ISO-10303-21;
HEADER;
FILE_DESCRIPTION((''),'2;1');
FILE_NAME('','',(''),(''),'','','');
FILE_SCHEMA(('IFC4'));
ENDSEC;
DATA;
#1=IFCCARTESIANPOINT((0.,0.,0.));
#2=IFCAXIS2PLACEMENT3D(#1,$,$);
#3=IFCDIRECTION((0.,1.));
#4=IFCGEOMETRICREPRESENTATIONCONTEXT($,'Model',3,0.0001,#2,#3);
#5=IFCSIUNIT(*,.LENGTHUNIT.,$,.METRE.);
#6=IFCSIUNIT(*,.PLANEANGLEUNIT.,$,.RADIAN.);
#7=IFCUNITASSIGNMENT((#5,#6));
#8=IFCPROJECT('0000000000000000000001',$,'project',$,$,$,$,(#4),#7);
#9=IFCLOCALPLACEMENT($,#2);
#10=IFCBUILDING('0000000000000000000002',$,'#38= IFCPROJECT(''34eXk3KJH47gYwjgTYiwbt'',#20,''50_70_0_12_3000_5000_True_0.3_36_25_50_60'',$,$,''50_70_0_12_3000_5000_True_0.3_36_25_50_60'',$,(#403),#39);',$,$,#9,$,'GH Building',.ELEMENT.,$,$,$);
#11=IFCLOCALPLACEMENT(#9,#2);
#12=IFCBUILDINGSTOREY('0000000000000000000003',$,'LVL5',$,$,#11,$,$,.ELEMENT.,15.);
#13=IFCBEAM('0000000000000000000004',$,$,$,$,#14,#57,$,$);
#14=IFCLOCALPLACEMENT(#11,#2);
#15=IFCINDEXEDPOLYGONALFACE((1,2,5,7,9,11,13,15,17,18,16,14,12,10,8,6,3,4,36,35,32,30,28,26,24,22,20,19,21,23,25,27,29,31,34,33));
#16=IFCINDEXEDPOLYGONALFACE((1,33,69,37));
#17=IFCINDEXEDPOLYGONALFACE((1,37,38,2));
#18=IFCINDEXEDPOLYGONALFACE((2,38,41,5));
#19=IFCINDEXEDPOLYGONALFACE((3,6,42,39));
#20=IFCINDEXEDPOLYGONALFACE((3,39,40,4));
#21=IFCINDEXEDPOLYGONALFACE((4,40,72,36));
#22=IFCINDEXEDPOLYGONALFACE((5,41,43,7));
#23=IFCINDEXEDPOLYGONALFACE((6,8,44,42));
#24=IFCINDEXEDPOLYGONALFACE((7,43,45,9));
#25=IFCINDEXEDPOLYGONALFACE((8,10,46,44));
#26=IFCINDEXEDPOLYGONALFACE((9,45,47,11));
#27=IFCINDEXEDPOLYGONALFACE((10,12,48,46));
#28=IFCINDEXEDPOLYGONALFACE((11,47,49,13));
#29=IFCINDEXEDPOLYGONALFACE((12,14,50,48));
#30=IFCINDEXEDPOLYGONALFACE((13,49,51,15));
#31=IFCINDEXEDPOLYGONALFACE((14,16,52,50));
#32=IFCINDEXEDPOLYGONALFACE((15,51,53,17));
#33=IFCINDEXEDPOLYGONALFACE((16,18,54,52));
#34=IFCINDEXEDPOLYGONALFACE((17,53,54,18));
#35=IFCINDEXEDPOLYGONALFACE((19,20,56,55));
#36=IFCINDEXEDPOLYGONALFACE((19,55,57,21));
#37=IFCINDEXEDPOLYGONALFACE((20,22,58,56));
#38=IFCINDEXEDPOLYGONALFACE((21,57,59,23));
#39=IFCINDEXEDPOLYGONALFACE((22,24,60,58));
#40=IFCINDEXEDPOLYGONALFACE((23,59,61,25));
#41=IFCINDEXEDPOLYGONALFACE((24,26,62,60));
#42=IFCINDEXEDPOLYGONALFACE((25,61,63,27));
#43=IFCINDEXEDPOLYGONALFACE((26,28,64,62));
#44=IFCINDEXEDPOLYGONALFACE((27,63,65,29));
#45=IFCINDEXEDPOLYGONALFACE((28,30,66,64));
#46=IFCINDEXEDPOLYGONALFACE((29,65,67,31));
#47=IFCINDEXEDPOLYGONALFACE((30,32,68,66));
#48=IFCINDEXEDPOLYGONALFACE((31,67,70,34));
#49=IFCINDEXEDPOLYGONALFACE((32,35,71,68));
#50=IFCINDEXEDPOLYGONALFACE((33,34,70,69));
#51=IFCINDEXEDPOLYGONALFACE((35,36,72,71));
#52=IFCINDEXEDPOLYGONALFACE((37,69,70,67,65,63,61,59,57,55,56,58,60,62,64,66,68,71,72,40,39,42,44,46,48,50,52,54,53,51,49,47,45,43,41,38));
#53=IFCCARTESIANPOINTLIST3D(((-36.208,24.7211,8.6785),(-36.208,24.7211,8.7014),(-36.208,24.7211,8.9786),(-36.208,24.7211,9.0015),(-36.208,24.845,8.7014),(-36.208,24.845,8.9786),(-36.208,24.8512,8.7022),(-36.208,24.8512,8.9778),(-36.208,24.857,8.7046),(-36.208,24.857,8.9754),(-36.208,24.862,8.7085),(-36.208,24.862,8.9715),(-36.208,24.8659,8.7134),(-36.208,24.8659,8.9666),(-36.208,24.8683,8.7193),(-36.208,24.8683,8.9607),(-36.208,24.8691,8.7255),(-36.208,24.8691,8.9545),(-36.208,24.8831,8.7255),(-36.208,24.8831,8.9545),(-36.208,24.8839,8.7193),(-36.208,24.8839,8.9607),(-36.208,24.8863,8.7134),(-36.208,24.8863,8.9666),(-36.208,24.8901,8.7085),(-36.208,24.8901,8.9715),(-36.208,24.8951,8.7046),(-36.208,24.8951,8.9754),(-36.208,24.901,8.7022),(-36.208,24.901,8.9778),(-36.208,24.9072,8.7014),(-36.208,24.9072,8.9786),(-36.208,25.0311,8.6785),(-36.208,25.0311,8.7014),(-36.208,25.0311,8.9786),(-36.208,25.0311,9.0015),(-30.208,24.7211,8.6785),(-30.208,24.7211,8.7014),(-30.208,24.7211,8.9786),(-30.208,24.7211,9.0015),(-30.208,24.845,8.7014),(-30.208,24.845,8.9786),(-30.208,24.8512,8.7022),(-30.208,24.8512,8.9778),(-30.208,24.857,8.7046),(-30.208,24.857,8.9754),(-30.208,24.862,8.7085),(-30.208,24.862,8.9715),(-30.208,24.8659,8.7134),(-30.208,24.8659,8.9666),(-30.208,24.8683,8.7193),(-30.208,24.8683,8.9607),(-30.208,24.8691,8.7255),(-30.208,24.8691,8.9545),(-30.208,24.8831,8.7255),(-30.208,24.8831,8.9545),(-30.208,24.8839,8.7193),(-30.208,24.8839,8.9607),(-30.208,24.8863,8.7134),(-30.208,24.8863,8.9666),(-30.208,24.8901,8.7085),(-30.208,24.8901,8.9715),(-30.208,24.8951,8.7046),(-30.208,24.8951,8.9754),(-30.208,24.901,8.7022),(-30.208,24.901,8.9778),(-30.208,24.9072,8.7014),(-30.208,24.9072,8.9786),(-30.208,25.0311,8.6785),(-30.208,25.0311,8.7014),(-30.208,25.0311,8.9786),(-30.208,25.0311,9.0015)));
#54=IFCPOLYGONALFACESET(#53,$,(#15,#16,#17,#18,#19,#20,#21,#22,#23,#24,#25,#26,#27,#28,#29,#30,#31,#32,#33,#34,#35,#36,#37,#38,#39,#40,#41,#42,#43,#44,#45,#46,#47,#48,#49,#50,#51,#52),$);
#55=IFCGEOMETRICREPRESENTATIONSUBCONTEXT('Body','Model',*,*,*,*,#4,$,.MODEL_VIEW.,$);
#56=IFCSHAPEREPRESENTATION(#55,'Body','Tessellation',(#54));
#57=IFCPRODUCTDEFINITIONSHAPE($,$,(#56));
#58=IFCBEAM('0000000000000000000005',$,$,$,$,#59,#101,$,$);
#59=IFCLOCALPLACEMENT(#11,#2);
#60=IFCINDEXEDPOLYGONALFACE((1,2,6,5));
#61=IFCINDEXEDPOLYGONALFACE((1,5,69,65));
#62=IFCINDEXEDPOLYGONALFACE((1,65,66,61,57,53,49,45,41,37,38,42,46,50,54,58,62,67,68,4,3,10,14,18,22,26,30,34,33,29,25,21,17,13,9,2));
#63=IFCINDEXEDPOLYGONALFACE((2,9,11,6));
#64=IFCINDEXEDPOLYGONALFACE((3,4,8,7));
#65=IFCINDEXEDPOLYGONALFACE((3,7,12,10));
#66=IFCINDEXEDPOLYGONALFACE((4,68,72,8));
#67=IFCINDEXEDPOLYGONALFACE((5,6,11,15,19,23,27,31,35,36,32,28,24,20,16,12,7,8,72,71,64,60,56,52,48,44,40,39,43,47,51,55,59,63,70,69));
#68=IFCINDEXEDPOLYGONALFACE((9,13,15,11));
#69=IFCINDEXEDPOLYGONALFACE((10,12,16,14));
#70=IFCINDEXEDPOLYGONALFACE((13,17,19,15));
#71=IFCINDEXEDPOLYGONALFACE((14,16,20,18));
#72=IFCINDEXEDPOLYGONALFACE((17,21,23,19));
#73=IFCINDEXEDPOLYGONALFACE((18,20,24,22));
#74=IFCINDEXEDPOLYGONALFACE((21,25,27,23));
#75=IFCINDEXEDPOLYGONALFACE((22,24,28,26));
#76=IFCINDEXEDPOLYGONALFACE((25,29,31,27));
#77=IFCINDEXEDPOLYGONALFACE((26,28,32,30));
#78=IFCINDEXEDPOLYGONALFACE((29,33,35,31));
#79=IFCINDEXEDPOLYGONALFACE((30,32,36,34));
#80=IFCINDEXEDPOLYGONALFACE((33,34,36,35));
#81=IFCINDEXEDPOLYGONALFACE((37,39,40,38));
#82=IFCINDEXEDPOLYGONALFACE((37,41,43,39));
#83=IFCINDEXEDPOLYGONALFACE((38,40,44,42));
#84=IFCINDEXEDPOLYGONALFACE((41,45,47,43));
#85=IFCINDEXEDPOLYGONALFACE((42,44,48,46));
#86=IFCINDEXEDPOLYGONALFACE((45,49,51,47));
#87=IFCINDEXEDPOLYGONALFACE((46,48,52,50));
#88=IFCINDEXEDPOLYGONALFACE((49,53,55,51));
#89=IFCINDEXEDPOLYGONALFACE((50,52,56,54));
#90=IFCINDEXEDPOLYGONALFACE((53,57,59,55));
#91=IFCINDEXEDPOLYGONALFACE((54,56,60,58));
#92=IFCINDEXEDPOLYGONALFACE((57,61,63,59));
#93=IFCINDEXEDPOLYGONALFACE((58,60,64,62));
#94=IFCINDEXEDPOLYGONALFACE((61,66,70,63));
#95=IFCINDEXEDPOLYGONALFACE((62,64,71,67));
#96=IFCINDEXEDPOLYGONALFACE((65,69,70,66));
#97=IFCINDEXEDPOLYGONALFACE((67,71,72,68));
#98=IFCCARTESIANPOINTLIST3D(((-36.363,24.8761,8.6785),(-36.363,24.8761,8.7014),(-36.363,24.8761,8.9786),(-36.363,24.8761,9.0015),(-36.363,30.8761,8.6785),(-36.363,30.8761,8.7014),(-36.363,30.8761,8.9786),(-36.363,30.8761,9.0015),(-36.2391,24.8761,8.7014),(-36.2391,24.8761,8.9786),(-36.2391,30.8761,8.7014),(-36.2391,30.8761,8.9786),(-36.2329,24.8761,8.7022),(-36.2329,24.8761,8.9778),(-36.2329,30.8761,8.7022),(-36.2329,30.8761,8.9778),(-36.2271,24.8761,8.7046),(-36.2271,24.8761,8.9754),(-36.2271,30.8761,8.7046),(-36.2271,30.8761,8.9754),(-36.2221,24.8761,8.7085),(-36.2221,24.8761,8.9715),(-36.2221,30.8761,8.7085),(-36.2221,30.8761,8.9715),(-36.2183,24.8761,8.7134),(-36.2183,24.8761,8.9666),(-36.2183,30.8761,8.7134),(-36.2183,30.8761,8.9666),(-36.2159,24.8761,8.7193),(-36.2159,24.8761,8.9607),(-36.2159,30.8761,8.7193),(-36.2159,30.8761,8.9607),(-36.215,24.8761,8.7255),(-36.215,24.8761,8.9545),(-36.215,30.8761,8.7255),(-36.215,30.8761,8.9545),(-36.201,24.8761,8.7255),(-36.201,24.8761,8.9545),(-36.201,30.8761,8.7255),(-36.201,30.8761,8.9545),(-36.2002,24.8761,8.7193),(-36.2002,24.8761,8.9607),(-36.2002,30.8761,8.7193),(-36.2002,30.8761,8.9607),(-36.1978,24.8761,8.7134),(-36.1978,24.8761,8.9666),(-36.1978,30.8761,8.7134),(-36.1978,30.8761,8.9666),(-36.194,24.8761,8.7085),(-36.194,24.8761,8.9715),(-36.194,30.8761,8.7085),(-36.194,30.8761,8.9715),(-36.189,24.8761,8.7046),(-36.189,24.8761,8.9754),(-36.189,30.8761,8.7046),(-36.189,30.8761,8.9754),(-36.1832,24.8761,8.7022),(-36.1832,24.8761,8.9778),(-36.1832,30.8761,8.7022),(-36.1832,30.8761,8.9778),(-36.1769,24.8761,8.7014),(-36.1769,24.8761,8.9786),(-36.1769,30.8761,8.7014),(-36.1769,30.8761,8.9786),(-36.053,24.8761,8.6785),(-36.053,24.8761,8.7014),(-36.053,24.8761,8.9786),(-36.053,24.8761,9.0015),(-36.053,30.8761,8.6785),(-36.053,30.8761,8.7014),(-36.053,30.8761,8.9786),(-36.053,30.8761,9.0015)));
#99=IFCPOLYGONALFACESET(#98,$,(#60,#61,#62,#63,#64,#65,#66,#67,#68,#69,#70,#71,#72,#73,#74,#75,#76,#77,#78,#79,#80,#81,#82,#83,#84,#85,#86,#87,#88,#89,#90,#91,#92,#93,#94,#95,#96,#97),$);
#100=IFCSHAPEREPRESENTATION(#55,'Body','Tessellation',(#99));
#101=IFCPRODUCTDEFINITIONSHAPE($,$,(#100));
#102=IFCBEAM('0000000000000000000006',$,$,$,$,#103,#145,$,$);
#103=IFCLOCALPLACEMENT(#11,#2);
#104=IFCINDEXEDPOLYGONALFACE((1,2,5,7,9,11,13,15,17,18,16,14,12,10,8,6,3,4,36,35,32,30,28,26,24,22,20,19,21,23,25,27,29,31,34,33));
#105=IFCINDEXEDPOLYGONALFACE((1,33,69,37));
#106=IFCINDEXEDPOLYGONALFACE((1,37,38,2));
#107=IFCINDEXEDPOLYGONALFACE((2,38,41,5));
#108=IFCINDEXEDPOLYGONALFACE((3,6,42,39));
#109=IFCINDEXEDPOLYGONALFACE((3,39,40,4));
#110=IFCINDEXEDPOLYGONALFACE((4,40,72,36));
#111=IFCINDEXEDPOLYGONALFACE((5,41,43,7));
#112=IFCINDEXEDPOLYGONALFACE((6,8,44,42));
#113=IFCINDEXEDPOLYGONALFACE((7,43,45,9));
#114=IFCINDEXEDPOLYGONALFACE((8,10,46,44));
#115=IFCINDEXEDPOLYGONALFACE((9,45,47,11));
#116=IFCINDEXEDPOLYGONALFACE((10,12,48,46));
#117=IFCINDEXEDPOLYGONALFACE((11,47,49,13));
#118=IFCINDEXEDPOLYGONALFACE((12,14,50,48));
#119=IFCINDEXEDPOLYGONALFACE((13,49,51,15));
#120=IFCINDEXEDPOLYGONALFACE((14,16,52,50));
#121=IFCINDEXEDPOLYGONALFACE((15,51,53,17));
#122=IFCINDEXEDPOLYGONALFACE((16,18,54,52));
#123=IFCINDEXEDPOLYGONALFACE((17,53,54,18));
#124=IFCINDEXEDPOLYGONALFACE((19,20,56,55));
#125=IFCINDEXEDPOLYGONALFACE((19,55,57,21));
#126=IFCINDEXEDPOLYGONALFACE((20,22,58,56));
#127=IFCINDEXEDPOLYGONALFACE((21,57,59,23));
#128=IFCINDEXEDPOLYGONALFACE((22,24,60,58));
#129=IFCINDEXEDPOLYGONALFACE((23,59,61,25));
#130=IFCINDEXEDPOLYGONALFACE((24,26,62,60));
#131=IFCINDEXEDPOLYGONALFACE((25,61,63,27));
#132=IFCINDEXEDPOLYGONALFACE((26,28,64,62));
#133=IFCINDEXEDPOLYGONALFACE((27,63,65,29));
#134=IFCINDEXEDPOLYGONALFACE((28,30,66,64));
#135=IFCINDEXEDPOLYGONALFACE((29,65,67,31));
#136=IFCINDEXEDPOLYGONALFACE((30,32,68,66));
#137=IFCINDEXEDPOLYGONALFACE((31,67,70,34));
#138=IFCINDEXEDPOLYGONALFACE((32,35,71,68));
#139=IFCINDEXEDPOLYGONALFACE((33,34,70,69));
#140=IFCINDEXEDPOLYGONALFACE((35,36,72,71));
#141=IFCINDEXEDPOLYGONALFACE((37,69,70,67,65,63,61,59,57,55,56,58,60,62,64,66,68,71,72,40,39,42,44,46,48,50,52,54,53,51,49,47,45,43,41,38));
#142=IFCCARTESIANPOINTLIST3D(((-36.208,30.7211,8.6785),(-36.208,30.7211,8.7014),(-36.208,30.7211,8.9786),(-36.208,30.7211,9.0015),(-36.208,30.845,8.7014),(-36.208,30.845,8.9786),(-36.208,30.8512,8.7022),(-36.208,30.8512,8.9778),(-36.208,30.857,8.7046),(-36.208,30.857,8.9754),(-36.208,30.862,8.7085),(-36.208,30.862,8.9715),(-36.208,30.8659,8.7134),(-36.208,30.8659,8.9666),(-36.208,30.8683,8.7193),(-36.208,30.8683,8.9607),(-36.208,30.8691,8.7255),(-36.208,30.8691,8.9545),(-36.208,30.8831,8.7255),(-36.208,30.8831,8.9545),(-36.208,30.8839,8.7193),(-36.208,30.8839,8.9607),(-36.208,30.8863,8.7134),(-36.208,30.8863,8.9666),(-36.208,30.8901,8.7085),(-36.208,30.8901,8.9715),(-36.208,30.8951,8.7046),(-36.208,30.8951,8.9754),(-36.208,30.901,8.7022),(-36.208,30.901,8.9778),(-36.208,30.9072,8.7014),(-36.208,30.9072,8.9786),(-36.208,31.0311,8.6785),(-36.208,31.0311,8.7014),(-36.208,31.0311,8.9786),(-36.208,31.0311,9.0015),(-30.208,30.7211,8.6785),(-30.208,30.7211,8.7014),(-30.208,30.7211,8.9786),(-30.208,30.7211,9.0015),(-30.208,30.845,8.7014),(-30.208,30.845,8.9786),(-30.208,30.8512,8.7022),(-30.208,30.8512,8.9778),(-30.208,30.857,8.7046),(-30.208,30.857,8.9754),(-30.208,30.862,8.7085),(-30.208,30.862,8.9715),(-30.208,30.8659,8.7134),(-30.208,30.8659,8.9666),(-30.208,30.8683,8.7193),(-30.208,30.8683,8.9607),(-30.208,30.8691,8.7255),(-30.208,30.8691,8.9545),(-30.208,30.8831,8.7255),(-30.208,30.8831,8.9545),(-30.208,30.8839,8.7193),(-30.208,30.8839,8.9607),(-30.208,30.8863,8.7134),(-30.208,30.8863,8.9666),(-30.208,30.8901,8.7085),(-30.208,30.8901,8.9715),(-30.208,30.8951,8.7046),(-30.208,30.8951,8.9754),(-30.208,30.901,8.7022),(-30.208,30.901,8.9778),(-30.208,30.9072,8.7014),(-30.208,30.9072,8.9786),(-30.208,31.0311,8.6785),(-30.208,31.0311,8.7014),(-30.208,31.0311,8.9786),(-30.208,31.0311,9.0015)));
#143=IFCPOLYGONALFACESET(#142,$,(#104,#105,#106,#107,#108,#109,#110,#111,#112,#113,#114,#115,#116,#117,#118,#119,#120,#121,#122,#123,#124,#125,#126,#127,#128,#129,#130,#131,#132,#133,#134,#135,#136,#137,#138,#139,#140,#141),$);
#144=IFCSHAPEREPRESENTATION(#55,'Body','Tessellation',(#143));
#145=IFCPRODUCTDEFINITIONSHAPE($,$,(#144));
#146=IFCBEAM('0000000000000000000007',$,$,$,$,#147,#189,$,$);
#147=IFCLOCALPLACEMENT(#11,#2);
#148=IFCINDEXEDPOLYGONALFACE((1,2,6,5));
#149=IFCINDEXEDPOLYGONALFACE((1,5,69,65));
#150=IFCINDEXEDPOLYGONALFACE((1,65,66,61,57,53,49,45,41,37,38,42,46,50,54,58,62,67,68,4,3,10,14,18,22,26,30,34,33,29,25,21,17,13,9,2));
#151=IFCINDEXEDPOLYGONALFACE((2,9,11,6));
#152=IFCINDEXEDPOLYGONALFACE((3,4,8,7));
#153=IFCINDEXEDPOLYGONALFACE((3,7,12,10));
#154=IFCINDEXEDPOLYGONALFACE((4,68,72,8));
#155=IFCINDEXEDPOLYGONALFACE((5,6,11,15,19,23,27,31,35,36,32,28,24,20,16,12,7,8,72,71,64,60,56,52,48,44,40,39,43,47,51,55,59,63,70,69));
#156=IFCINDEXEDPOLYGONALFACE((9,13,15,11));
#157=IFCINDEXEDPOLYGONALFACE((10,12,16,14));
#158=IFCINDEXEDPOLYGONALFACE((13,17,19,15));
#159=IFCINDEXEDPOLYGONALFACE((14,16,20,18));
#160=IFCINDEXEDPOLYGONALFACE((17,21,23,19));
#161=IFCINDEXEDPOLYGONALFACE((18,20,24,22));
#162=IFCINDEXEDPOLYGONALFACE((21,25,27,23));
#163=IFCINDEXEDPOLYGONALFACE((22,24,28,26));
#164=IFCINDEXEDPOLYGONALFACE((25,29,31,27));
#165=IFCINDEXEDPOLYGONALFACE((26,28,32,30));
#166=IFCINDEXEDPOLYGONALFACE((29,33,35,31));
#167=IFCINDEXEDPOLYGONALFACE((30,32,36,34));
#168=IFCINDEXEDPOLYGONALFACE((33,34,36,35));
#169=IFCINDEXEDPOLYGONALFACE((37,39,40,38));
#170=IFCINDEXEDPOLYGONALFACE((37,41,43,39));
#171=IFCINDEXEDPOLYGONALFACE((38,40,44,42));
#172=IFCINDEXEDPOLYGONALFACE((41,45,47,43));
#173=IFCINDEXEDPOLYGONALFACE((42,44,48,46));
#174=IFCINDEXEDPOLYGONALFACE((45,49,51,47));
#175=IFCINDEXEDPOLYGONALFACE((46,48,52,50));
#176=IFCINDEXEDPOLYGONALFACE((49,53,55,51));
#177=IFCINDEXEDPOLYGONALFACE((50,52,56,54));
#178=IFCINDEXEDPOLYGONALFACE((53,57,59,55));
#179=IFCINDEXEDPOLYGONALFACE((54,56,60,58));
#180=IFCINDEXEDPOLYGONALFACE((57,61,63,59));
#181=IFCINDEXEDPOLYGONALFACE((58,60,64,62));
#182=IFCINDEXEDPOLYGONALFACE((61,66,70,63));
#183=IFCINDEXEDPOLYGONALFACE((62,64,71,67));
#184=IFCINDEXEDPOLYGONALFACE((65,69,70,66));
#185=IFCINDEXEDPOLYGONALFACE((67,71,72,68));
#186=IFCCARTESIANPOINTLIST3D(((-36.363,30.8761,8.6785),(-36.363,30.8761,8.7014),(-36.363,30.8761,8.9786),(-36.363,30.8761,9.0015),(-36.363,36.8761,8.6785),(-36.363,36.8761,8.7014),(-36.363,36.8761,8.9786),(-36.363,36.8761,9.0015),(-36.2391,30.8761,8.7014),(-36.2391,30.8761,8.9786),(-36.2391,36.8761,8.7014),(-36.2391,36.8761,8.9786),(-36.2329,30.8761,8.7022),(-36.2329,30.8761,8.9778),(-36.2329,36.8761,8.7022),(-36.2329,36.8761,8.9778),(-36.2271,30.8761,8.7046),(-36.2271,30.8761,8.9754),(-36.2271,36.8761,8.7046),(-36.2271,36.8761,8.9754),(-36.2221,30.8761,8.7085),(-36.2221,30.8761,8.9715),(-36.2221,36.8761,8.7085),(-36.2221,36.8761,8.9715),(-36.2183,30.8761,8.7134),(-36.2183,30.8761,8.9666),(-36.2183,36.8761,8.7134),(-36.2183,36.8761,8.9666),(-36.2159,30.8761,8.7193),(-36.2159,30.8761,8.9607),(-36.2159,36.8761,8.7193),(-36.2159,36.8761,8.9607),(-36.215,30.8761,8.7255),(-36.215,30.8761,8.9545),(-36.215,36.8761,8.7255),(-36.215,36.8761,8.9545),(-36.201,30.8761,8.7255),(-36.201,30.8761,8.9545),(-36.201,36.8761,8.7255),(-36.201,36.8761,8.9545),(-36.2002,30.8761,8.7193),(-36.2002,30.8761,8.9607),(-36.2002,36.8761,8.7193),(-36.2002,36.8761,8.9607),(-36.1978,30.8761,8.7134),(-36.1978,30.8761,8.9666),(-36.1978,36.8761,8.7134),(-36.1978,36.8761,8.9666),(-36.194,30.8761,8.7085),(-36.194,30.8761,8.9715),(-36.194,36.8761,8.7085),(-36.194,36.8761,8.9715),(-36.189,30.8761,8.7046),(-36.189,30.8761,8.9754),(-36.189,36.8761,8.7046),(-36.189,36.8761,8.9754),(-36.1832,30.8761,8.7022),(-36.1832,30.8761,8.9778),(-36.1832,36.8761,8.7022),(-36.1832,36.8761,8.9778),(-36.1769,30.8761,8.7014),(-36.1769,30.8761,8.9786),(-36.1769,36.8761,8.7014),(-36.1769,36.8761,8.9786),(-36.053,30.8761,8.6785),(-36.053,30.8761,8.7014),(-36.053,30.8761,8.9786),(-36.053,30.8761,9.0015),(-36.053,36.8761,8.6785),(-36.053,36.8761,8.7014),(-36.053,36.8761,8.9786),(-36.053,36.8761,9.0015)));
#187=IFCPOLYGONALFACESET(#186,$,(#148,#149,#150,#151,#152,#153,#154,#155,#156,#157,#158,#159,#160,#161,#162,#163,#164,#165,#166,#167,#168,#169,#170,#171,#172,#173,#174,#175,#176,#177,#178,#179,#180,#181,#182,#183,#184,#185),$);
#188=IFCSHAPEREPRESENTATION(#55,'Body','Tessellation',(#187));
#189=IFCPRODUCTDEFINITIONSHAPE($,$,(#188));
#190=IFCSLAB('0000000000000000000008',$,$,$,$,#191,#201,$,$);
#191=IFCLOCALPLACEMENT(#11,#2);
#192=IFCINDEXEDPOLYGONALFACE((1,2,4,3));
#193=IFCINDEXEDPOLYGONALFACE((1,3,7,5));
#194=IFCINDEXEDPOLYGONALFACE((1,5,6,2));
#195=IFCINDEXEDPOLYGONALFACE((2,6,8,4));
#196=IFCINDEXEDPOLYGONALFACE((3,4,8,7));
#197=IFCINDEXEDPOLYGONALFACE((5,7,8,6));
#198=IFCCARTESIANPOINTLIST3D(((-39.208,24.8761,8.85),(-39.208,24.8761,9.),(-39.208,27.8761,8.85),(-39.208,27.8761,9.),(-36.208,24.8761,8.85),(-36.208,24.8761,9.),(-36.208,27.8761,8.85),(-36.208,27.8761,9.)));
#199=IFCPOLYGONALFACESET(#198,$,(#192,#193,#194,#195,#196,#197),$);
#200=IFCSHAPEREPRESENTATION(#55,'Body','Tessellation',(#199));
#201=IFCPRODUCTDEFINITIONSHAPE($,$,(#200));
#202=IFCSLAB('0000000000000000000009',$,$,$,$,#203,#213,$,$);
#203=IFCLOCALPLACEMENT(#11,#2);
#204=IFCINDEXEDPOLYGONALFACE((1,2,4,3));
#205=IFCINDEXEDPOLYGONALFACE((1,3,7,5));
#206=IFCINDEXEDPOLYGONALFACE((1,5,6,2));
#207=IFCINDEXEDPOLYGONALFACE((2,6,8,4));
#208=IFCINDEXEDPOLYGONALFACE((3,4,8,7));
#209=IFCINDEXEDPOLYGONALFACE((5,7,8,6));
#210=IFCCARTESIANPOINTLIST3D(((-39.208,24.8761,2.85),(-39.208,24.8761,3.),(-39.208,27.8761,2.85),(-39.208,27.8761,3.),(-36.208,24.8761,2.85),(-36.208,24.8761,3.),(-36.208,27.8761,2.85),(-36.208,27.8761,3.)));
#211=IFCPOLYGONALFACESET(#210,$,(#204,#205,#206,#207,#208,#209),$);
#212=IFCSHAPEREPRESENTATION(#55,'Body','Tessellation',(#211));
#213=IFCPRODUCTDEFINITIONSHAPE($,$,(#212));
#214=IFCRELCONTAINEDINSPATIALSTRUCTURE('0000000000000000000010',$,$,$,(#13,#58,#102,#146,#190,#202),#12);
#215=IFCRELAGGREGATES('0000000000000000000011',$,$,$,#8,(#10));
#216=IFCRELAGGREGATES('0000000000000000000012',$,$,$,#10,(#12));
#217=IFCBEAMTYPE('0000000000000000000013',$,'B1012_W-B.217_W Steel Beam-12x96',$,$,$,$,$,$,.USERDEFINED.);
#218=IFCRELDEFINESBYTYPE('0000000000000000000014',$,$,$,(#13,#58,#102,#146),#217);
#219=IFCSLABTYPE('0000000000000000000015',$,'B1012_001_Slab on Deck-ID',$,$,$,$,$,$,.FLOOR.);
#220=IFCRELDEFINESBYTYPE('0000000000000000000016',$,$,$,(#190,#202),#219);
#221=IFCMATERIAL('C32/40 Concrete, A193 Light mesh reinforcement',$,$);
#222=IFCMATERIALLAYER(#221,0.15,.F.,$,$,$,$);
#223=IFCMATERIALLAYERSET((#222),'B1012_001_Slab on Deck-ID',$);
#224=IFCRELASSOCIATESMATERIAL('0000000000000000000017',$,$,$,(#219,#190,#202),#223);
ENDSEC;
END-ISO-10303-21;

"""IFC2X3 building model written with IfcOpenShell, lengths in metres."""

from ifc_helpers import new_model, si_unit, direction, frame, origin, origin_2d, place, context, subcontext, project, spatial, polyline, i_section, outline, extrude, material, layer, layer_set, layer_usage, type_object, element, save


model = new_model("IFC2X3")

# Units and contexts
model_context = context("Model", 3, precision=0.0001, world=origin(), true_north=direction((0.0, 1.0)))
body_context = subcontext(model_context, "Body", "Model", "MODEL_VIEW")
ifc_project = project(units=[si_unit("LENGTHUNIT", "METRE"), si_unit("PLANEANGLEUNIT", "RADIAN")], contexts=[model_context])

# Building, storey
building_placement = place(None, origin())
building = spatial("IfcBuilding", under=ifc_project, at=building_placement, Name="#38= IFCPROJECT('34eXk3KJH47gYwjgTYiwbt',#20,'50_70_0_12_3000_5000_True_0.3_36_25_50_60',$,$,'50_70_0_12_3000_5000_True_0.3_36_25_50_60',$,(#403),#39);", LongName="GH Building", CompositionType="ELEMENT")
storey_placement = place(building_placement, origin())
storey = spatial("IfcBuildingStorey", under=building, at=storey_placement, Name="LVL5", CompositionType="ELEMENT", Elevation=15.0)

# Beams
beam_type = type_object("IfcBeamType", Name="B1012_W-B.217_W Steel Beam-12x96", PredefinedType="USERDEFINED")
for number, where, z_axis, x_axis in (
    (1, (-36.208, 24.8761, 8.84), (1.0, 0.0, 0.0), (0.0, 1.0, 0.0)),
    (2, (-36.208, 24.8761, 8.84), (0.0, 1.0, 0.0), (-1.0, 0.0, 0.0)),
    (3, (-36.208, 30.8761, 8.84), (1.0, 0.0, 0.0), (0.0, 1.0, 0.0)),
    (4, (-36.208, 30.8761, 8.84), (0.0, 1.0, 0.0), (-1.0, 0.0, 0.0)),
):
    element("IfcBeam", number, at=place(storey_placement, frame(where, z_axis=z_axis, x_axis=x_axis)), inside=storey, type_object=beam_type, context=body_context, shape_type="SweptSolid", body=[
        extrude(i_section(OverallWidth=0.31, OverallDepth=0.323, WebThickness=0.014, FlangeThickness=0.0229, FilletRadius=0.0241, at=origin_2d()), origin(), (0.0, 0.0, 1.0), 6.0),
    ])

# Slabs
ifc_material_1 = material(Name="C32/40 Concrete, A193 Light mesh reinforcement")
ifc_layer_1 = layer(ifc_material_1, 0.15, ventilated=False)
ifc_layer_set_1 = layer_set([ifc_layer_1], Name="B1012_001_Slab on Deck-ID")
ifc_layer_usage_1 = layer_usage(ifc_layer_set_1, "AXIS3", "NEGATIVE", -0.15)
slab_type = type_object("IfcSlabType", Name="B1012_001_Slab on Deck-ID", PredefinedType="FLOOR", material=ifc_layer_set_1)
slab_1_placement = place(storey_placement, frame((-37.708, 26.3761, 8.85)))
element("IfcSlab", 5, at=slab_1_placement, inside=storey, type_object=slab_type, material=ifc_layer_usage_1, context=body_context, shape_type="SweptSolid", body=[
    extrude(outline(polyline([(1.5, -1.5), (-1.5, -1.5), (-1.5, 1.5), (1.5, 1.5), (1.5, -1.5)])), origin(), (0.0, 0.0, 1.0), 0.15),
])
ifc_layer_usage_2 = layer_usage(ifc_layer_set_1, "AXIS3", "NEGATIVE", -0.15)
slab_2_placement = place(storey_placement, frame((-37.708, 26.3761, 2.85)))
element("IfcSlab", 6, at=slab_2_placement, inside=storey, type_object=slab_type, material=ifc_layer_usage_2, context=body_context, shape_type="SweptSolid", body=[
    extrude(outline(polyline([(1.5, -1.5), (-1.5, -1.5), (-1.5, 1.5), (1.5, 1.5), (1.5, -1.5)])), origin(), (0.0, 0.0, 1.0), 0.15),
])

save(model, "model.ifc")
